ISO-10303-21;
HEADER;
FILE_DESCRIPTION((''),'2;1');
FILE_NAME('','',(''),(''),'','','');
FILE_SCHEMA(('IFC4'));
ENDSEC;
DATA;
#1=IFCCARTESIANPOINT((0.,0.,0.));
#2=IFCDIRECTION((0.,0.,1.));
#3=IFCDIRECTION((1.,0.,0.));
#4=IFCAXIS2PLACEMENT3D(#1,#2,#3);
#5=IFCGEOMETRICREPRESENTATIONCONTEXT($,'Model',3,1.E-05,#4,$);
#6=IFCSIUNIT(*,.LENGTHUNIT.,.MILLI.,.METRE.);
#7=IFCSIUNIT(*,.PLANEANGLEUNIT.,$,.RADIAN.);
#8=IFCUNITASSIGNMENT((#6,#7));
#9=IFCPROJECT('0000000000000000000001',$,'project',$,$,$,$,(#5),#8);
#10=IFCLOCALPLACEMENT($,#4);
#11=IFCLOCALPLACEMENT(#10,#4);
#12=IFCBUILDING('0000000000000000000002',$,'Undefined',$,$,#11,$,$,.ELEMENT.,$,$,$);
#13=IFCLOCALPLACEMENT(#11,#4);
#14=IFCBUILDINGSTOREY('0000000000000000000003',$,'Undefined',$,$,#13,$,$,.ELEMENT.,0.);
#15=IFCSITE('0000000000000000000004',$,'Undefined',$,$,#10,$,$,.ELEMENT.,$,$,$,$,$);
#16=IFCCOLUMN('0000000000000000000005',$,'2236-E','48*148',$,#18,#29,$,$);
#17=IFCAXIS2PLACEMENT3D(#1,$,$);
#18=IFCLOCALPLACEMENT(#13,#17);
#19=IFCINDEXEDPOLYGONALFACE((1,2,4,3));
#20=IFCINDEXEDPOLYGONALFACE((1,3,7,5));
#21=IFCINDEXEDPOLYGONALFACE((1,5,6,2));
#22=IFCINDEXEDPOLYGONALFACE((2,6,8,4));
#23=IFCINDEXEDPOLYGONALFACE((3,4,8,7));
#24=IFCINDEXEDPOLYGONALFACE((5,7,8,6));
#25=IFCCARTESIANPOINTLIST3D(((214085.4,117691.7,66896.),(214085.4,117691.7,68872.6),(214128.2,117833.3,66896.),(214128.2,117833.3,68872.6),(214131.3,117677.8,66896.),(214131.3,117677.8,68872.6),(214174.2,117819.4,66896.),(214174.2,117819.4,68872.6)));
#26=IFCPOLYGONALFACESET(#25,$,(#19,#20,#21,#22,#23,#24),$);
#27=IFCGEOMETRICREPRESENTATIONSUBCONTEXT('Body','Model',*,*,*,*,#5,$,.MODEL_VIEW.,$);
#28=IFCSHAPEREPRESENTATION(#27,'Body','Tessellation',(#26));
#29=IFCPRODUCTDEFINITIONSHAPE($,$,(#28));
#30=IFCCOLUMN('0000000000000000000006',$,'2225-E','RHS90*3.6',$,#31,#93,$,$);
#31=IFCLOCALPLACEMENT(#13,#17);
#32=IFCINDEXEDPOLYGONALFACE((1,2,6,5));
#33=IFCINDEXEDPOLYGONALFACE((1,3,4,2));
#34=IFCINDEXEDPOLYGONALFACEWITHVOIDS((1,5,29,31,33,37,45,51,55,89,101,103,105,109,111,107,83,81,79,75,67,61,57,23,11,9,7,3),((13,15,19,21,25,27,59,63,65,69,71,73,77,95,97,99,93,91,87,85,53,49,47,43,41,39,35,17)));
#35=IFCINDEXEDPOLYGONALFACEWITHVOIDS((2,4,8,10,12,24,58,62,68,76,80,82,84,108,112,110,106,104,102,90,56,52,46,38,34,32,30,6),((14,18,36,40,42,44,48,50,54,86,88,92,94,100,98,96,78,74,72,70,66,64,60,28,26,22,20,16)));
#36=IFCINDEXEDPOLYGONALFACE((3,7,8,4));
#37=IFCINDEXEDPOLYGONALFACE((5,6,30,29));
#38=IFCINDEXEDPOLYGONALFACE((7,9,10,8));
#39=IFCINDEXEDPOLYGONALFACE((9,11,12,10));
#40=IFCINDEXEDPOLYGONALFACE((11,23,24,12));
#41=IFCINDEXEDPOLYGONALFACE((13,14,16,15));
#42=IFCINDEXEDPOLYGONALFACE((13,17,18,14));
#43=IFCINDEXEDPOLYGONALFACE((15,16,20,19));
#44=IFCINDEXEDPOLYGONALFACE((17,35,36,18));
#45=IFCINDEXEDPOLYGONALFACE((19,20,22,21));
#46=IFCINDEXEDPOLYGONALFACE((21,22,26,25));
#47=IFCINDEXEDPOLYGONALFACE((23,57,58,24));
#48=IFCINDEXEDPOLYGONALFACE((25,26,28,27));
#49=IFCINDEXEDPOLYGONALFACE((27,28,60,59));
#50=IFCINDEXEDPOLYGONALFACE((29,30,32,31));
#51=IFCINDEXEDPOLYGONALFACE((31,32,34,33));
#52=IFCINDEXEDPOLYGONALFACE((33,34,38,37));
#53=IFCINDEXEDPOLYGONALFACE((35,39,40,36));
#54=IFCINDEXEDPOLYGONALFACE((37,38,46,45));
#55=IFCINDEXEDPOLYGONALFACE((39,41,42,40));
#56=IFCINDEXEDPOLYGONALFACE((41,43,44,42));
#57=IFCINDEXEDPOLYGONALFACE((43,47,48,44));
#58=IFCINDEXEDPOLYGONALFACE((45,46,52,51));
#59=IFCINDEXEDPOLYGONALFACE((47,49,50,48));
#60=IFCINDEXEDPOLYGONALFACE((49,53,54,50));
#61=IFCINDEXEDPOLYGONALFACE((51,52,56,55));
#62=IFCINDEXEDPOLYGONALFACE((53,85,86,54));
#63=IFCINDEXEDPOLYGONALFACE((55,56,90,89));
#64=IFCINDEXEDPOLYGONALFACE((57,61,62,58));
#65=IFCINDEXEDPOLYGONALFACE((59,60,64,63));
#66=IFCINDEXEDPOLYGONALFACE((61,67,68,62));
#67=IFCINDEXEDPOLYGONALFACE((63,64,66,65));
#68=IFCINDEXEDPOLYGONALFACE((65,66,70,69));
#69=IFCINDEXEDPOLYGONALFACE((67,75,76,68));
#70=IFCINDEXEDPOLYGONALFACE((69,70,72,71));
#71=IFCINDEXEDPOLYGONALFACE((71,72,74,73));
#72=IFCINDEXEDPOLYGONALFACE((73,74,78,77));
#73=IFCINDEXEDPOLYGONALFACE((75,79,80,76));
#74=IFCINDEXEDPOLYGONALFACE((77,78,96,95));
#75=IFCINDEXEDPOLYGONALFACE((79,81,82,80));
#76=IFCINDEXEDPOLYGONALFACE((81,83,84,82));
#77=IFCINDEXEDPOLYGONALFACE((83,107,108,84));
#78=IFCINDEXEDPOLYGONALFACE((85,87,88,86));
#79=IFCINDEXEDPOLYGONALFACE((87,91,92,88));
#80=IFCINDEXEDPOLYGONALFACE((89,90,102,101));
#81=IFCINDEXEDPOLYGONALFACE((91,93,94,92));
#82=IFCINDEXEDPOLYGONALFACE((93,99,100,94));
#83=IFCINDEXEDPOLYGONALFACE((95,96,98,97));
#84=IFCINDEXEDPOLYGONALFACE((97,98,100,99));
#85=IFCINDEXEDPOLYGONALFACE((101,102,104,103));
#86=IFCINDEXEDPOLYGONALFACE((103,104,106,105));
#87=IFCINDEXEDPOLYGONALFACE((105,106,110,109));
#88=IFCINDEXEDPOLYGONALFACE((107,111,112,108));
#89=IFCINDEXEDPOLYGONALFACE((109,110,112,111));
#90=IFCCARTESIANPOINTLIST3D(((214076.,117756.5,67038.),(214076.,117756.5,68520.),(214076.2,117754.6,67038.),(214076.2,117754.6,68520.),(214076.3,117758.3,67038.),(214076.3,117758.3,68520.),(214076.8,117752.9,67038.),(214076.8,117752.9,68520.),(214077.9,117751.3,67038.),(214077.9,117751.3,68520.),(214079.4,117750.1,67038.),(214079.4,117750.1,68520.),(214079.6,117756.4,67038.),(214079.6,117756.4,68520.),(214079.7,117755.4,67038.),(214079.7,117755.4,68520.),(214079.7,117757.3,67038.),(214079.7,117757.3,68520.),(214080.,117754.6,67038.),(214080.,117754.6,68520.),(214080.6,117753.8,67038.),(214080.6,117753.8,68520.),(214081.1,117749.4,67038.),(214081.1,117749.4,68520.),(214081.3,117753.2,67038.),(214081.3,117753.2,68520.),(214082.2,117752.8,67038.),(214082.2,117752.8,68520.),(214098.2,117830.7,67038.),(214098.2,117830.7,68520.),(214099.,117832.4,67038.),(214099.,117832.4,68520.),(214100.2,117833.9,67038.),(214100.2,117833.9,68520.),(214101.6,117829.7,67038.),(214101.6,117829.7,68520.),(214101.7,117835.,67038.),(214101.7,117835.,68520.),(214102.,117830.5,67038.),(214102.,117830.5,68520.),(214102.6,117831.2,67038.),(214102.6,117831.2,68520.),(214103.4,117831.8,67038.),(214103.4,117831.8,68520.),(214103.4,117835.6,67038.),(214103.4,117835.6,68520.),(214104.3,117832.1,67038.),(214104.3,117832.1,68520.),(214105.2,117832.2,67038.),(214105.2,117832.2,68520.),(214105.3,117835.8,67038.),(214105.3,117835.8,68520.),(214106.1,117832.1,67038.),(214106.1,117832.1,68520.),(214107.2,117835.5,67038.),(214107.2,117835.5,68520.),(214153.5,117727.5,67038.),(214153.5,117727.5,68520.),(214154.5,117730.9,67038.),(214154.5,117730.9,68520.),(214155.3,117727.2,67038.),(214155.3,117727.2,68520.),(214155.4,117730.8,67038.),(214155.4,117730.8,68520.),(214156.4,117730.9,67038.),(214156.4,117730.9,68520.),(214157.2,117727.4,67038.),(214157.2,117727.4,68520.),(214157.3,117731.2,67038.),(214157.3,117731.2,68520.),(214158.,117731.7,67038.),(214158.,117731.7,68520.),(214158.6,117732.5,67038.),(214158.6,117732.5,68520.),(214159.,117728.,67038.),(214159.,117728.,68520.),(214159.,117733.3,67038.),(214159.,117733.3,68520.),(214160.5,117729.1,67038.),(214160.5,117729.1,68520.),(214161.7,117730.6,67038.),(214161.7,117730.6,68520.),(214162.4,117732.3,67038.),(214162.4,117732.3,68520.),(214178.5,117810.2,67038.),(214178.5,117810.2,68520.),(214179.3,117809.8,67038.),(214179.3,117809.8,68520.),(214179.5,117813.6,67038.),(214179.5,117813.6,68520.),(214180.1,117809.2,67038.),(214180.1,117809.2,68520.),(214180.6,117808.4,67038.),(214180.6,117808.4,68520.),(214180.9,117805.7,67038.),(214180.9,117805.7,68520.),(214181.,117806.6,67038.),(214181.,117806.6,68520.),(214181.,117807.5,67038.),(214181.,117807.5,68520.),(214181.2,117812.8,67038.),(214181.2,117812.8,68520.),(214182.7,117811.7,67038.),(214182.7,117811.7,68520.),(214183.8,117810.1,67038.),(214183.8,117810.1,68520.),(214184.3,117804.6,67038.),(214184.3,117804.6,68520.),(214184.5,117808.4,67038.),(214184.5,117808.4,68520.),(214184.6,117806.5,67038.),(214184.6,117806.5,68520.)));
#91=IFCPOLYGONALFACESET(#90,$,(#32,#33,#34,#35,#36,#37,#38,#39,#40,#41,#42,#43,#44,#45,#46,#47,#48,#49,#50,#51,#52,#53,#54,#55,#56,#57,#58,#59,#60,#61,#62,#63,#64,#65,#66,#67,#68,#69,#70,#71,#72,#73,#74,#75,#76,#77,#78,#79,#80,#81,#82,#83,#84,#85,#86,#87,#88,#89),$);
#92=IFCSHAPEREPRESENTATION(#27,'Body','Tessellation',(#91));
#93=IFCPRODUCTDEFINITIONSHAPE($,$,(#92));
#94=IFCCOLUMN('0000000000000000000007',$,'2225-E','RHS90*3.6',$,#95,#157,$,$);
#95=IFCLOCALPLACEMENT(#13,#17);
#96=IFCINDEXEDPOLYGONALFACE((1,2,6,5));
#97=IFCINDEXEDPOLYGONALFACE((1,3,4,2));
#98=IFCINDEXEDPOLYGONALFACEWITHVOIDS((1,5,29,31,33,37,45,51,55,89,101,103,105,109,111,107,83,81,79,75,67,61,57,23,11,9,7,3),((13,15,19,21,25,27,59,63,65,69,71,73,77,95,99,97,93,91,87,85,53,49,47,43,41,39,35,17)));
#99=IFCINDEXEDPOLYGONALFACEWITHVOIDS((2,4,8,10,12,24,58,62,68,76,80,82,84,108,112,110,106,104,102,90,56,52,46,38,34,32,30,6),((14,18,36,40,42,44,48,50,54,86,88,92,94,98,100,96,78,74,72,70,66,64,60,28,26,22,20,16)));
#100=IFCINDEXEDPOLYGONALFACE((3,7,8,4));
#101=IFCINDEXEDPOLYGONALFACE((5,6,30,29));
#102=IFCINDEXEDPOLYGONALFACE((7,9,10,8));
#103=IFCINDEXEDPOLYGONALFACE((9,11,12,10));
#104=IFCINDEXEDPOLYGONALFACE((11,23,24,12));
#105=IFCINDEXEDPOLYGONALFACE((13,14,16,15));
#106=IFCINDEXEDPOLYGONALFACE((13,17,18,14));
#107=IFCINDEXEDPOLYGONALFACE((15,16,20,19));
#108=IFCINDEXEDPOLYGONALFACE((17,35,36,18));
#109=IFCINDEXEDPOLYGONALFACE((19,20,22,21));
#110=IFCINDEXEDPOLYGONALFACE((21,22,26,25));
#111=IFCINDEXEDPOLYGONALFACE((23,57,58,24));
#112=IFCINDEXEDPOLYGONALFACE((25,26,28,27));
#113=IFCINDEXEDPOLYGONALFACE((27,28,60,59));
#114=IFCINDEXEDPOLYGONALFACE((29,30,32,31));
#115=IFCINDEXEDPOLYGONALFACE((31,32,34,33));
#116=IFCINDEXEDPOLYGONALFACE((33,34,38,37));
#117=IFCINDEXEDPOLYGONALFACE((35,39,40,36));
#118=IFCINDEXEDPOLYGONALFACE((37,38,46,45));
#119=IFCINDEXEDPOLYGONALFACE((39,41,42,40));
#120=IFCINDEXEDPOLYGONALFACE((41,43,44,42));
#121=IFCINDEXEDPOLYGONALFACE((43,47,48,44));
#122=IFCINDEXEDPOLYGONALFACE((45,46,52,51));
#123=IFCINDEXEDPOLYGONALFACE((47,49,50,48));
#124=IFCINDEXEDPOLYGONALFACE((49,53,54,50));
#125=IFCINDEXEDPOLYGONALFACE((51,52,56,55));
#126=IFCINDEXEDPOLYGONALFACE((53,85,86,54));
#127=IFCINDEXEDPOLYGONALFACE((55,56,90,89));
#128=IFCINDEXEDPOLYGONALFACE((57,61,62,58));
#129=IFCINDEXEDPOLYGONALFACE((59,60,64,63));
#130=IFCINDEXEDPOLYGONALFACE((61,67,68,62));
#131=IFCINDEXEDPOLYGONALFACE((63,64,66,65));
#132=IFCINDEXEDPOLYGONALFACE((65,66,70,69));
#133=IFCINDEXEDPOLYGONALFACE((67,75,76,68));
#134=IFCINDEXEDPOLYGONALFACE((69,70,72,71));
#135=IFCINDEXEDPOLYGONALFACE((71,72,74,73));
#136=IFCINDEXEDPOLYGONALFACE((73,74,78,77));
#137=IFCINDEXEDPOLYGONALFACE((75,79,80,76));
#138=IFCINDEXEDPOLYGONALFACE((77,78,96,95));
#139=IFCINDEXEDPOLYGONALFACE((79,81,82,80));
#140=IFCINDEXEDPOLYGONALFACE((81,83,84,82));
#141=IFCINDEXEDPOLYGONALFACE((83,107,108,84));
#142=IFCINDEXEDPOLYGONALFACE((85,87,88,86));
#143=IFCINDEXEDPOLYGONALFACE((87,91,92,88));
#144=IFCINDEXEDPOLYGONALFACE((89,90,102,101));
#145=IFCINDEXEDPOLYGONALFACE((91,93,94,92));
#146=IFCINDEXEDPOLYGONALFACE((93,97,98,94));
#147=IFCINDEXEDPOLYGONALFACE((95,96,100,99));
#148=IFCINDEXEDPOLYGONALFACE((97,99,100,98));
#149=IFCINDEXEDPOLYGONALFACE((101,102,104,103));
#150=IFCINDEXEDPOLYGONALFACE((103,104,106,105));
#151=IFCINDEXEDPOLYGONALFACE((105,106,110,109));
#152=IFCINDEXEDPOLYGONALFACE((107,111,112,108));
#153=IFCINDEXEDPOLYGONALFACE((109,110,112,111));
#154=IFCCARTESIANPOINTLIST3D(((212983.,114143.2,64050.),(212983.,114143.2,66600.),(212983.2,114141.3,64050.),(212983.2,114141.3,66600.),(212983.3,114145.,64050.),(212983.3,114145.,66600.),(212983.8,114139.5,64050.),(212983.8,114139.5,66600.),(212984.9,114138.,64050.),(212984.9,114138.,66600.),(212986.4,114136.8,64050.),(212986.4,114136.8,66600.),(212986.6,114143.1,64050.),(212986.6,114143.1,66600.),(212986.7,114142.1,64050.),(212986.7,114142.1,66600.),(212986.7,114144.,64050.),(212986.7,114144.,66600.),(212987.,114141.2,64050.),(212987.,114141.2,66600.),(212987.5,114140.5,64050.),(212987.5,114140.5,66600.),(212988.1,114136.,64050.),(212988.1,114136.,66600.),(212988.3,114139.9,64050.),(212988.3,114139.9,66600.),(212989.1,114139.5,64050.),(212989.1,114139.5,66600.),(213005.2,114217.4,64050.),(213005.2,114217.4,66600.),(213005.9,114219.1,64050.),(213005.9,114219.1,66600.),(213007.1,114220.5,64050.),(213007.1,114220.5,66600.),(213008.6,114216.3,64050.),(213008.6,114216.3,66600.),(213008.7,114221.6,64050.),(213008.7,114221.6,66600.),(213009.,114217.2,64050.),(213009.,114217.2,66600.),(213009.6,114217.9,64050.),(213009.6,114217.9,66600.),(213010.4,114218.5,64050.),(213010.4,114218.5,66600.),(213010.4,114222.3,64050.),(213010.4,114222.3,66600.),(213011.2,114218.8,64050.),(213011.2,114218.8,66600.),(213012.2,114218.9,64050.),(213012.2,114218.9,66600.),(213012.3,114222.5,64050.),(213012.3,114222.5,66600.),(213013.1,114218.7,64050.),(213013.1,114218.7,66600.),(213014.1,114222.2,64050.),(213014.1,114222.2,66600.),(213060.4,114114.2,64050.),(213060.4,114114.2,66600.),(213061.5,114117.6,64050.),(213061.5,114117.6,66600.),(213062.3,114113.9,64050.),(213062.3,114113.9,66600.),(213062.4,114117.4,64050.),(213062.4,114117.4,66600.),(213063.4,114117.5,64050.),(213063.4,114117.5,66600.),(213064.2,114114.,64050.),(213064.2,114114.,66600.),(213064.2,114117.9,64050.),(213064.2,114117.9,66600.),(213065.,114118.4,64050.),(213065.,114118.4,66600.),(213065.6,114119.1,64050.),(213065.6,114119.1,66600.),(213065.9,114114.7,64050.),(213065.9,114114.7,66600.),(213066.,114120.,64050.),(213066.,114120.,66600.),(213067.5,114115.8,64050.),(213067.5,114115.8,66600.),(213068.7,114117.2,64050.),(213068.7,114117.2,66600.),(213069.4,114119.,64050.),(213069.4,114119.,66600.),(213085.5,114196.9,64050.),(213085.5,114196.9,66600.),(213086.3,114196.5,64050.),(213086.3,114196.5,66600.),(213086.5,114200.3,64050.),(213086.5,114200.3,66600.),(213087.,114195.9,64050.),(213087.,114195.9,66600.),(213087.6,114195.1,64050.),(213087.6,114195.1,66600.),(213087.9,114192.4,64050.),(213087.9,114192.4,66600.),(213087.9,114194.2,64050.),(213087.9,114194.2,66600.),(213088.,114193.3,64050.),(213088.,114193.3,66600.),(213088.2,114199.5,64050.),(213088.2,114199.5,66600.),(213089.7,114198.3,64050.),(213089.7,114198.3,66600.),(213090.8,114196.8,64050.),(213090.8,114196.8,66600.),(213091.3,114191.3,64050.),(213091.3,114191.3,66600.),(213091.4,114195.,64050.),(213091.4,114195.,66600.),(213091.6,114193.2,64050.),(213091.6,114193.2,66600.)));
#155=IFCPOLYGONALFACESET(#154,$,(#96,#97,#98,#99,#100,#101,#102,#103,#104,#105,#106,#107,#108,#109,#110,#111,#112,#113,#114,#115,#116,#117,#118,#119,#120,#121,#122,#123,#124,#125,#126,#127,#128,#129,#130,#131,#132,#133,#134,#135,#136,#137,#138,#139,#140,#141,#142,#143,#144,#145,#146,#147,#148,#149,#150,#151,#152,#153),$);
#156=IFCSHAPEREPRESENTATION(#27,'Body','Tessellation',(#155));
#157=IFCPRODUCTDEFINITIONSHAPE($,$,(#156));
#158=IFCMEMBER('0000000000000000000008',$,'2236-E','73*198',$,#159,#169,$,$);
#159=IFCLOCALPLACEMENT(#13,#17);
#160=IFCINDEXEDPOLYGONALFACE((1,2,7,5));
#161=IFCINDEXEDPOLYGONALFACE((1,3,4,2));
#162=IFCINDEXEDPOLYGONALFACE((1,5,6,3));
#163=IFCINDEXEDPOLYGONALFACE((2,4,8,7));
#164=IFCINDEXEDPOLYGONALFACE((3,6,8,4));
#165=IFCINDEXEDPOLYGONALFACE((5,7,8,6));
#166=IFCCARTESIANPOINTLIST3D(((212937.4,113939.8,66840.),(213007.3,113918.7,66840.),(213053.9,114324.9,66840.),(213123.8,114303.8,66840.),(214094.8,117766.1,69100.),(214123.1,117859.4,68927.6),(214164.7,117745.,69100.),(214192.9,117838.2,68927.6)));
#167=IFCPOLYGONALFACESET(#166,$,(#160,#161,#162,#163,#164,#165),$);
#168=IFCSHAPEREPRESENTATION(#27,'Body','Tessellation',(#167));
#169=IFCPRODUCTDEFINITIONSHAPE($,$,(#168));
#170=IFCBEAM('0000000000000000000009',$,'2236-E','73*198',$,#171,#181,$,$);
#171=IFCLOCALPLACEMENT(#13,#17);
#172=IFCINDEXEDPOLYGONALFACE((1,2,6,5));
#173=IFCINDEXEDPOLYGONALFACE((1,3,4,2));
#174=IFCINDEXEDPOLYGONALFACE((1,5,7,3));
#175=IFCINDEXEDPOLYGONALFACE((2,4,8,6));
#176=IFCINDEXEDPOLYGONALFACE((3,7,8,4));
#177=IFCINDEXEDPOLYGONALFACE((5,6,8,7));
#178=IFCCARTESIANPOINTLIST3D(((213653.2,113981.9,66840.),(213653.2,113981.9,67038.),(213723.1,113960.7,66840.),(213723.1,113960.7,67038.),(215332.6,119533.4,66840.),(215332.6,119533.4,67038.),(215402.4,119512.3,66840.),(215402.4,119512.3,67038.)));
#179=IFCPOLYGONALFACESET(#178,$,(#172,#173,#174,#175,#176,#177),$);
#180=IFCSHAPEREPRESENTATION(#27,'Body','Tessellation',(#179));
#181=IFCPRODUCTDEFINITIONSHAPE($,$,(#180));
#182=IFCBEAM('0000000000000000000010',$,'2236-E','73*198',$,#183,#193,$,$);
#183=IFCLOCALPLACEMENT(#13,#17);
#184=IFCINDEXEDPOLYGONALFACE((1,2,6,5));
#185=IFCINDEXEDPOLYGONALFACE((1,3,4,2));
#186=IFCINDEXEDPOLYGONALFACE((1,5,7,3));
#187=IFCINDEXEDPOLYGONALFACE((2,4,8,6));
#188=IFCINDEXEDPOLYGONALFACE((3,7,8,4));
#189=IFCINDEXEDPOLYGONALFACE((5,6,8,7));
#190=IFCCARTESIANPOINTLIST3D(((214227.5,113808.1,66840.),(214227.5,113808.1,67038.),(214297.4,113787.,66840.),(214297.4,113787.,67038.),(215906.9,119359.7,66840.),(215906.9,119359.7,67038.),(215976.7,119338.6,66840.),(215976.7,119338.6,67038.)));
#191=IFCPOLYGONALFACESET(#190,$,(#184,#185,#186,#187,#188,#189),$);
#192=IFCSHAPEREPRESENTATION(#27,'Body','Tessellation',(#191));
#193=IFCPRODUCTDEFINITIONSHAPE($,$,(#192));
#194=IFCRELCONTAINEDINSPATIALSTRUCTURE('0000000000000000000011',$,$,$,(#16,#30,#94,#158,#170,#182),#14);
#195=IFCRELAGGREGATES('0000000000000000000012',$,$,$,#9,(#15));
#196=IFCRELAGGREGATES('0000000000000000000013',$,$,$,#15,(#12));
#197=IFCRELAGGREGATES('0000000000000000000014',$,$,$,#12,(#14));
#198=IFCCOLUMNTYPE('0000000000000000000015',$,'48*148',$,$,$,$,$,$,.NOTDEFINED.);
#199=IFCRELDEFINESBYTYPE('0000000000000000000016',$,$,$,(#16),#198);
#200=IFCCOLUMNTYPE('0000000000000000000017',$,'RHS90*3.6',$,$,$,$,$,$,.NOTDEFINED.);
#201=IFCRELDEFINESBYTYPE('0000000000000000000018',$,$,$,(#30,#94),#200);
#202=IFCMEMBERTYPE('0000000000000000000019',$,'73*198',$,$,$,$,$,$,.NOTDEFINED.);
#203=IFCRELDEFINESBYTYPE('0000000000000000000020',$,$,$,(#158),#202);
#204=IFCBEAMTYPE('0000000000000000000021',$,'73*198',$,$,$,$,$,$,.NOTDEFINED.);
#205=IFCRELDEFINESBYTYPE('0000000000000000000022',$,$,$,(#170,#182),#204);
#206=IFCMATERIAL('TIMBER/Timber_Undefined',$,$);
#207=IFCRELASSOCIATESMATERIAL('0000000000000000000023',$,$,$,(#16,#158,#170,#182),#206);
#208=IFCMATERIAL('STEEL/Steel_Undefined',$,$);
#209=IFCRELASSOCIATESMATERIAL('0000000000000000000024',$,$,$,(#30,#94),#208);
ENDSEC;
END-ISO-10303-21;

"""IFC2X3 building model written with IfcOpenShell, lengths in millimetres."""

from ifc_helpers import new_model, si_unit, frame, origin_with_axes, origin_2d_with_axis, place, context, subcontext, project, spatial, rectangle, hollow_rectangle, extrude, clip, halfspace, material, type_object, element, save


model = new_model("IFC2X3")

# Units and contexts
model_context = context("Model", 3, precision=1e-05, world=origin_with_axes())
body_context = subcontext(model_context, "Body", "Model", "MODEL_VIEW")
ifc_project = project(units=[si_unit("LENGTHUNIT", "METRE", prefix="MILLI"), si_unit("PLANEANGLEUNIT", "RADIAN")], contexts=[model_context])

# Site, building, storey
site_placement = place(None, origin_with_axes())
site = spatial("IfcSite", under=ifc_project, at=site_placement, Name="Undefined", CompositionType="ELEMENT")
building_placement = place(site_placement, origin_with_axes())
building = spatial("IfcBuilding", under=site, at=building_placement, Name="Undefined", CompositionType="ELEMENT")
storey_placement = place(building_placement, origin_with_axes())
storey = spatial("IfcBuildingStorey", under=building, at=storey_placement, Name="Undefined", CompositionType="ELEMENT", Elevation=0.0)

# Columns
ifc_material_1 = material(Name="TIMBER/Timber_Undefined")
column_type_1 = type_object("IfcColumnType", Name="48*148", PredefinedType="NOTDEFINED")
column_1_placement = place(storey_placement, frame((214129.8, 117755.5, 68872.6), z_axis=(0.0, 0.0, -1.0), x_axis=(0.957167, -0.289538, 0.0)))
element("IfcColumn", 1, at=column_1_placement, inside=storey, type_object=column_type_1, material=ifc_material_1, Name="2236-E", Description="48*148", context=body_context, shape_type="SweptSolid", body=[
    extrude(rectangle(XDim=148.0, YDim=48.0, at=origin_2d_with_axis()), frame((0.0, 0.0, 1976.6), z_axis=(0.0, 0.0, -1.0), x_axis=(0.0, 1.0, 0.0)), (0.0, 0.0, 1.0), 1976.6),
])
ifc_material_2 = material(Name="STEEL/Steel_Undefined")
column_type_2 = type_object("IfcColumnType", Name="RHS90*3.6", PredefinedType="NOTDEFINED")
column_2_placement = place(storey_placement, frame((214130.3, 117781.5, 67038.0), z_axis=(0.0, 0.0, 1.0), x_axis=(-0.957167, 0.289538, 0.0)))
element("IfcColumn", 2, at=column_2_placement, inside=storey, type_object=column_type_2, material=ifc_material_2, Name="2225-E", Description="RHS90*3.6", context=body_context, shape_type="SweptSolid", body=[
    extrude(hollow_rectangle(XDim=90.0, YDim=90.0, WallThickness=3.6, InnerFilletRadius=3.6, OuterFilletRadius=7.2, at=origin_2d_with_axis()), frame((0.0, 0.0, 1482.0), z_axis=(0.0, 0.0, -1.0), x_axis=(0.0, 1.0, 0.0)), (0.0, 0.0, 1.0), 1482.0),
])
column_3_placement = place(storey_placement, frame((213037.3, 114168.2, 64050.0), z_axis=(0.0, 0.0, 1.0), x_axis=(-0.957167, 0.289538, 0.0)))
element("IfcColumn", 3, at=column_3_placement, inside=storey, type_object=column_type_2, material=ifc_material_2, Name="2225-E", Description="RHS90*3.6", context=body_context, shape_type="SweptSolid", body=[
    extrude(hollow_rectangle(XDim=90.0, YDim=90.0, WallThickness=3.6, InnerFilletRadius=3.6, OuterFilletRadius=7.2, at=origin_2d_with_axis()), frame((0.0, 0.0, 2550.0), z_axis=(0.0, 0.0, -1.0), x_axis=(0.0, 1.0, 0.0)), (0.0, 0.0, 1.0), 2550.0),
])

# Member
member_type_1 = type_object("IfcMemberType", Name="73*198", PredefinedType="NOTDEFINED")
member_1_placement = place(storey_placement, frame((214143.9, 117802.2, 69013.8), z_axis=(-0.957167, 0.289538, 0.0), x_axis=(-0.252047, -0.833226, -0.492144)))
element("IfcMember", 4, at=member_1_placement, inside=storey, type_object=member_type_1, material=ifc_material_1, Name="2236-E", Description="73*198", context=body_context, shape_type="Clipping", body=[
    clip(extrude(rectangle(XDim=198.0, YDim=73.0, at=origin_2d_with_axis()), frame((9448.4, 0.0, 0.0), z_axis=(-1.0, 0.0, 0.0), x_axis=(0.0, -1.0, 0.0)), (0.0, 0.0, 1.0), 9448.5), halfspace(frame((4746.1, 186.1, 36.5), z_axis=(0.492144, -0.870514, 0.0), x_axis=(0.0, 0.0, -1.0)), False)),
])

# Beams
beam_type_1 = type_object("IfcBeamType", Name="73*198", PredefinedType="NOTDEFINED")
for number, where, z_axis, x_axis, name in (
    (5, (213688.2, 113971.3, 66939.0), (-0.957167, 0.289538, 0.0), (0.289538, 0.957166, 0.0), "2236-E"),
    (6, (214262.5, 113797.6, 66939.0), (-0.957167, 0.289538, 0.0), (0.289538, 0.957166, 0.0), "2236-E"),
):
    element("IfcBeam", number, at=place(storey_placement, frame(where, z_axis=z_axis, x_axis=x_axis)), inside=storey, type_object=beam_type_1, material=ifc_material_1, Name=name, Description="73*198", context=body_context, shape_type="SweptSolid", body=[
        extrude(rectangle(XDim=198.0, YDim=73.0, at=origin_2d_with_axis()), frame((5800.0, 0.0, 0.0), z_axis=(-1.0, 0.0, 0.0), x_axis=(0.0, -1.0, 0.0)), (0.0, 0.0, 1.0), 5800.0),
    ])

save(model, "model.ifc")
